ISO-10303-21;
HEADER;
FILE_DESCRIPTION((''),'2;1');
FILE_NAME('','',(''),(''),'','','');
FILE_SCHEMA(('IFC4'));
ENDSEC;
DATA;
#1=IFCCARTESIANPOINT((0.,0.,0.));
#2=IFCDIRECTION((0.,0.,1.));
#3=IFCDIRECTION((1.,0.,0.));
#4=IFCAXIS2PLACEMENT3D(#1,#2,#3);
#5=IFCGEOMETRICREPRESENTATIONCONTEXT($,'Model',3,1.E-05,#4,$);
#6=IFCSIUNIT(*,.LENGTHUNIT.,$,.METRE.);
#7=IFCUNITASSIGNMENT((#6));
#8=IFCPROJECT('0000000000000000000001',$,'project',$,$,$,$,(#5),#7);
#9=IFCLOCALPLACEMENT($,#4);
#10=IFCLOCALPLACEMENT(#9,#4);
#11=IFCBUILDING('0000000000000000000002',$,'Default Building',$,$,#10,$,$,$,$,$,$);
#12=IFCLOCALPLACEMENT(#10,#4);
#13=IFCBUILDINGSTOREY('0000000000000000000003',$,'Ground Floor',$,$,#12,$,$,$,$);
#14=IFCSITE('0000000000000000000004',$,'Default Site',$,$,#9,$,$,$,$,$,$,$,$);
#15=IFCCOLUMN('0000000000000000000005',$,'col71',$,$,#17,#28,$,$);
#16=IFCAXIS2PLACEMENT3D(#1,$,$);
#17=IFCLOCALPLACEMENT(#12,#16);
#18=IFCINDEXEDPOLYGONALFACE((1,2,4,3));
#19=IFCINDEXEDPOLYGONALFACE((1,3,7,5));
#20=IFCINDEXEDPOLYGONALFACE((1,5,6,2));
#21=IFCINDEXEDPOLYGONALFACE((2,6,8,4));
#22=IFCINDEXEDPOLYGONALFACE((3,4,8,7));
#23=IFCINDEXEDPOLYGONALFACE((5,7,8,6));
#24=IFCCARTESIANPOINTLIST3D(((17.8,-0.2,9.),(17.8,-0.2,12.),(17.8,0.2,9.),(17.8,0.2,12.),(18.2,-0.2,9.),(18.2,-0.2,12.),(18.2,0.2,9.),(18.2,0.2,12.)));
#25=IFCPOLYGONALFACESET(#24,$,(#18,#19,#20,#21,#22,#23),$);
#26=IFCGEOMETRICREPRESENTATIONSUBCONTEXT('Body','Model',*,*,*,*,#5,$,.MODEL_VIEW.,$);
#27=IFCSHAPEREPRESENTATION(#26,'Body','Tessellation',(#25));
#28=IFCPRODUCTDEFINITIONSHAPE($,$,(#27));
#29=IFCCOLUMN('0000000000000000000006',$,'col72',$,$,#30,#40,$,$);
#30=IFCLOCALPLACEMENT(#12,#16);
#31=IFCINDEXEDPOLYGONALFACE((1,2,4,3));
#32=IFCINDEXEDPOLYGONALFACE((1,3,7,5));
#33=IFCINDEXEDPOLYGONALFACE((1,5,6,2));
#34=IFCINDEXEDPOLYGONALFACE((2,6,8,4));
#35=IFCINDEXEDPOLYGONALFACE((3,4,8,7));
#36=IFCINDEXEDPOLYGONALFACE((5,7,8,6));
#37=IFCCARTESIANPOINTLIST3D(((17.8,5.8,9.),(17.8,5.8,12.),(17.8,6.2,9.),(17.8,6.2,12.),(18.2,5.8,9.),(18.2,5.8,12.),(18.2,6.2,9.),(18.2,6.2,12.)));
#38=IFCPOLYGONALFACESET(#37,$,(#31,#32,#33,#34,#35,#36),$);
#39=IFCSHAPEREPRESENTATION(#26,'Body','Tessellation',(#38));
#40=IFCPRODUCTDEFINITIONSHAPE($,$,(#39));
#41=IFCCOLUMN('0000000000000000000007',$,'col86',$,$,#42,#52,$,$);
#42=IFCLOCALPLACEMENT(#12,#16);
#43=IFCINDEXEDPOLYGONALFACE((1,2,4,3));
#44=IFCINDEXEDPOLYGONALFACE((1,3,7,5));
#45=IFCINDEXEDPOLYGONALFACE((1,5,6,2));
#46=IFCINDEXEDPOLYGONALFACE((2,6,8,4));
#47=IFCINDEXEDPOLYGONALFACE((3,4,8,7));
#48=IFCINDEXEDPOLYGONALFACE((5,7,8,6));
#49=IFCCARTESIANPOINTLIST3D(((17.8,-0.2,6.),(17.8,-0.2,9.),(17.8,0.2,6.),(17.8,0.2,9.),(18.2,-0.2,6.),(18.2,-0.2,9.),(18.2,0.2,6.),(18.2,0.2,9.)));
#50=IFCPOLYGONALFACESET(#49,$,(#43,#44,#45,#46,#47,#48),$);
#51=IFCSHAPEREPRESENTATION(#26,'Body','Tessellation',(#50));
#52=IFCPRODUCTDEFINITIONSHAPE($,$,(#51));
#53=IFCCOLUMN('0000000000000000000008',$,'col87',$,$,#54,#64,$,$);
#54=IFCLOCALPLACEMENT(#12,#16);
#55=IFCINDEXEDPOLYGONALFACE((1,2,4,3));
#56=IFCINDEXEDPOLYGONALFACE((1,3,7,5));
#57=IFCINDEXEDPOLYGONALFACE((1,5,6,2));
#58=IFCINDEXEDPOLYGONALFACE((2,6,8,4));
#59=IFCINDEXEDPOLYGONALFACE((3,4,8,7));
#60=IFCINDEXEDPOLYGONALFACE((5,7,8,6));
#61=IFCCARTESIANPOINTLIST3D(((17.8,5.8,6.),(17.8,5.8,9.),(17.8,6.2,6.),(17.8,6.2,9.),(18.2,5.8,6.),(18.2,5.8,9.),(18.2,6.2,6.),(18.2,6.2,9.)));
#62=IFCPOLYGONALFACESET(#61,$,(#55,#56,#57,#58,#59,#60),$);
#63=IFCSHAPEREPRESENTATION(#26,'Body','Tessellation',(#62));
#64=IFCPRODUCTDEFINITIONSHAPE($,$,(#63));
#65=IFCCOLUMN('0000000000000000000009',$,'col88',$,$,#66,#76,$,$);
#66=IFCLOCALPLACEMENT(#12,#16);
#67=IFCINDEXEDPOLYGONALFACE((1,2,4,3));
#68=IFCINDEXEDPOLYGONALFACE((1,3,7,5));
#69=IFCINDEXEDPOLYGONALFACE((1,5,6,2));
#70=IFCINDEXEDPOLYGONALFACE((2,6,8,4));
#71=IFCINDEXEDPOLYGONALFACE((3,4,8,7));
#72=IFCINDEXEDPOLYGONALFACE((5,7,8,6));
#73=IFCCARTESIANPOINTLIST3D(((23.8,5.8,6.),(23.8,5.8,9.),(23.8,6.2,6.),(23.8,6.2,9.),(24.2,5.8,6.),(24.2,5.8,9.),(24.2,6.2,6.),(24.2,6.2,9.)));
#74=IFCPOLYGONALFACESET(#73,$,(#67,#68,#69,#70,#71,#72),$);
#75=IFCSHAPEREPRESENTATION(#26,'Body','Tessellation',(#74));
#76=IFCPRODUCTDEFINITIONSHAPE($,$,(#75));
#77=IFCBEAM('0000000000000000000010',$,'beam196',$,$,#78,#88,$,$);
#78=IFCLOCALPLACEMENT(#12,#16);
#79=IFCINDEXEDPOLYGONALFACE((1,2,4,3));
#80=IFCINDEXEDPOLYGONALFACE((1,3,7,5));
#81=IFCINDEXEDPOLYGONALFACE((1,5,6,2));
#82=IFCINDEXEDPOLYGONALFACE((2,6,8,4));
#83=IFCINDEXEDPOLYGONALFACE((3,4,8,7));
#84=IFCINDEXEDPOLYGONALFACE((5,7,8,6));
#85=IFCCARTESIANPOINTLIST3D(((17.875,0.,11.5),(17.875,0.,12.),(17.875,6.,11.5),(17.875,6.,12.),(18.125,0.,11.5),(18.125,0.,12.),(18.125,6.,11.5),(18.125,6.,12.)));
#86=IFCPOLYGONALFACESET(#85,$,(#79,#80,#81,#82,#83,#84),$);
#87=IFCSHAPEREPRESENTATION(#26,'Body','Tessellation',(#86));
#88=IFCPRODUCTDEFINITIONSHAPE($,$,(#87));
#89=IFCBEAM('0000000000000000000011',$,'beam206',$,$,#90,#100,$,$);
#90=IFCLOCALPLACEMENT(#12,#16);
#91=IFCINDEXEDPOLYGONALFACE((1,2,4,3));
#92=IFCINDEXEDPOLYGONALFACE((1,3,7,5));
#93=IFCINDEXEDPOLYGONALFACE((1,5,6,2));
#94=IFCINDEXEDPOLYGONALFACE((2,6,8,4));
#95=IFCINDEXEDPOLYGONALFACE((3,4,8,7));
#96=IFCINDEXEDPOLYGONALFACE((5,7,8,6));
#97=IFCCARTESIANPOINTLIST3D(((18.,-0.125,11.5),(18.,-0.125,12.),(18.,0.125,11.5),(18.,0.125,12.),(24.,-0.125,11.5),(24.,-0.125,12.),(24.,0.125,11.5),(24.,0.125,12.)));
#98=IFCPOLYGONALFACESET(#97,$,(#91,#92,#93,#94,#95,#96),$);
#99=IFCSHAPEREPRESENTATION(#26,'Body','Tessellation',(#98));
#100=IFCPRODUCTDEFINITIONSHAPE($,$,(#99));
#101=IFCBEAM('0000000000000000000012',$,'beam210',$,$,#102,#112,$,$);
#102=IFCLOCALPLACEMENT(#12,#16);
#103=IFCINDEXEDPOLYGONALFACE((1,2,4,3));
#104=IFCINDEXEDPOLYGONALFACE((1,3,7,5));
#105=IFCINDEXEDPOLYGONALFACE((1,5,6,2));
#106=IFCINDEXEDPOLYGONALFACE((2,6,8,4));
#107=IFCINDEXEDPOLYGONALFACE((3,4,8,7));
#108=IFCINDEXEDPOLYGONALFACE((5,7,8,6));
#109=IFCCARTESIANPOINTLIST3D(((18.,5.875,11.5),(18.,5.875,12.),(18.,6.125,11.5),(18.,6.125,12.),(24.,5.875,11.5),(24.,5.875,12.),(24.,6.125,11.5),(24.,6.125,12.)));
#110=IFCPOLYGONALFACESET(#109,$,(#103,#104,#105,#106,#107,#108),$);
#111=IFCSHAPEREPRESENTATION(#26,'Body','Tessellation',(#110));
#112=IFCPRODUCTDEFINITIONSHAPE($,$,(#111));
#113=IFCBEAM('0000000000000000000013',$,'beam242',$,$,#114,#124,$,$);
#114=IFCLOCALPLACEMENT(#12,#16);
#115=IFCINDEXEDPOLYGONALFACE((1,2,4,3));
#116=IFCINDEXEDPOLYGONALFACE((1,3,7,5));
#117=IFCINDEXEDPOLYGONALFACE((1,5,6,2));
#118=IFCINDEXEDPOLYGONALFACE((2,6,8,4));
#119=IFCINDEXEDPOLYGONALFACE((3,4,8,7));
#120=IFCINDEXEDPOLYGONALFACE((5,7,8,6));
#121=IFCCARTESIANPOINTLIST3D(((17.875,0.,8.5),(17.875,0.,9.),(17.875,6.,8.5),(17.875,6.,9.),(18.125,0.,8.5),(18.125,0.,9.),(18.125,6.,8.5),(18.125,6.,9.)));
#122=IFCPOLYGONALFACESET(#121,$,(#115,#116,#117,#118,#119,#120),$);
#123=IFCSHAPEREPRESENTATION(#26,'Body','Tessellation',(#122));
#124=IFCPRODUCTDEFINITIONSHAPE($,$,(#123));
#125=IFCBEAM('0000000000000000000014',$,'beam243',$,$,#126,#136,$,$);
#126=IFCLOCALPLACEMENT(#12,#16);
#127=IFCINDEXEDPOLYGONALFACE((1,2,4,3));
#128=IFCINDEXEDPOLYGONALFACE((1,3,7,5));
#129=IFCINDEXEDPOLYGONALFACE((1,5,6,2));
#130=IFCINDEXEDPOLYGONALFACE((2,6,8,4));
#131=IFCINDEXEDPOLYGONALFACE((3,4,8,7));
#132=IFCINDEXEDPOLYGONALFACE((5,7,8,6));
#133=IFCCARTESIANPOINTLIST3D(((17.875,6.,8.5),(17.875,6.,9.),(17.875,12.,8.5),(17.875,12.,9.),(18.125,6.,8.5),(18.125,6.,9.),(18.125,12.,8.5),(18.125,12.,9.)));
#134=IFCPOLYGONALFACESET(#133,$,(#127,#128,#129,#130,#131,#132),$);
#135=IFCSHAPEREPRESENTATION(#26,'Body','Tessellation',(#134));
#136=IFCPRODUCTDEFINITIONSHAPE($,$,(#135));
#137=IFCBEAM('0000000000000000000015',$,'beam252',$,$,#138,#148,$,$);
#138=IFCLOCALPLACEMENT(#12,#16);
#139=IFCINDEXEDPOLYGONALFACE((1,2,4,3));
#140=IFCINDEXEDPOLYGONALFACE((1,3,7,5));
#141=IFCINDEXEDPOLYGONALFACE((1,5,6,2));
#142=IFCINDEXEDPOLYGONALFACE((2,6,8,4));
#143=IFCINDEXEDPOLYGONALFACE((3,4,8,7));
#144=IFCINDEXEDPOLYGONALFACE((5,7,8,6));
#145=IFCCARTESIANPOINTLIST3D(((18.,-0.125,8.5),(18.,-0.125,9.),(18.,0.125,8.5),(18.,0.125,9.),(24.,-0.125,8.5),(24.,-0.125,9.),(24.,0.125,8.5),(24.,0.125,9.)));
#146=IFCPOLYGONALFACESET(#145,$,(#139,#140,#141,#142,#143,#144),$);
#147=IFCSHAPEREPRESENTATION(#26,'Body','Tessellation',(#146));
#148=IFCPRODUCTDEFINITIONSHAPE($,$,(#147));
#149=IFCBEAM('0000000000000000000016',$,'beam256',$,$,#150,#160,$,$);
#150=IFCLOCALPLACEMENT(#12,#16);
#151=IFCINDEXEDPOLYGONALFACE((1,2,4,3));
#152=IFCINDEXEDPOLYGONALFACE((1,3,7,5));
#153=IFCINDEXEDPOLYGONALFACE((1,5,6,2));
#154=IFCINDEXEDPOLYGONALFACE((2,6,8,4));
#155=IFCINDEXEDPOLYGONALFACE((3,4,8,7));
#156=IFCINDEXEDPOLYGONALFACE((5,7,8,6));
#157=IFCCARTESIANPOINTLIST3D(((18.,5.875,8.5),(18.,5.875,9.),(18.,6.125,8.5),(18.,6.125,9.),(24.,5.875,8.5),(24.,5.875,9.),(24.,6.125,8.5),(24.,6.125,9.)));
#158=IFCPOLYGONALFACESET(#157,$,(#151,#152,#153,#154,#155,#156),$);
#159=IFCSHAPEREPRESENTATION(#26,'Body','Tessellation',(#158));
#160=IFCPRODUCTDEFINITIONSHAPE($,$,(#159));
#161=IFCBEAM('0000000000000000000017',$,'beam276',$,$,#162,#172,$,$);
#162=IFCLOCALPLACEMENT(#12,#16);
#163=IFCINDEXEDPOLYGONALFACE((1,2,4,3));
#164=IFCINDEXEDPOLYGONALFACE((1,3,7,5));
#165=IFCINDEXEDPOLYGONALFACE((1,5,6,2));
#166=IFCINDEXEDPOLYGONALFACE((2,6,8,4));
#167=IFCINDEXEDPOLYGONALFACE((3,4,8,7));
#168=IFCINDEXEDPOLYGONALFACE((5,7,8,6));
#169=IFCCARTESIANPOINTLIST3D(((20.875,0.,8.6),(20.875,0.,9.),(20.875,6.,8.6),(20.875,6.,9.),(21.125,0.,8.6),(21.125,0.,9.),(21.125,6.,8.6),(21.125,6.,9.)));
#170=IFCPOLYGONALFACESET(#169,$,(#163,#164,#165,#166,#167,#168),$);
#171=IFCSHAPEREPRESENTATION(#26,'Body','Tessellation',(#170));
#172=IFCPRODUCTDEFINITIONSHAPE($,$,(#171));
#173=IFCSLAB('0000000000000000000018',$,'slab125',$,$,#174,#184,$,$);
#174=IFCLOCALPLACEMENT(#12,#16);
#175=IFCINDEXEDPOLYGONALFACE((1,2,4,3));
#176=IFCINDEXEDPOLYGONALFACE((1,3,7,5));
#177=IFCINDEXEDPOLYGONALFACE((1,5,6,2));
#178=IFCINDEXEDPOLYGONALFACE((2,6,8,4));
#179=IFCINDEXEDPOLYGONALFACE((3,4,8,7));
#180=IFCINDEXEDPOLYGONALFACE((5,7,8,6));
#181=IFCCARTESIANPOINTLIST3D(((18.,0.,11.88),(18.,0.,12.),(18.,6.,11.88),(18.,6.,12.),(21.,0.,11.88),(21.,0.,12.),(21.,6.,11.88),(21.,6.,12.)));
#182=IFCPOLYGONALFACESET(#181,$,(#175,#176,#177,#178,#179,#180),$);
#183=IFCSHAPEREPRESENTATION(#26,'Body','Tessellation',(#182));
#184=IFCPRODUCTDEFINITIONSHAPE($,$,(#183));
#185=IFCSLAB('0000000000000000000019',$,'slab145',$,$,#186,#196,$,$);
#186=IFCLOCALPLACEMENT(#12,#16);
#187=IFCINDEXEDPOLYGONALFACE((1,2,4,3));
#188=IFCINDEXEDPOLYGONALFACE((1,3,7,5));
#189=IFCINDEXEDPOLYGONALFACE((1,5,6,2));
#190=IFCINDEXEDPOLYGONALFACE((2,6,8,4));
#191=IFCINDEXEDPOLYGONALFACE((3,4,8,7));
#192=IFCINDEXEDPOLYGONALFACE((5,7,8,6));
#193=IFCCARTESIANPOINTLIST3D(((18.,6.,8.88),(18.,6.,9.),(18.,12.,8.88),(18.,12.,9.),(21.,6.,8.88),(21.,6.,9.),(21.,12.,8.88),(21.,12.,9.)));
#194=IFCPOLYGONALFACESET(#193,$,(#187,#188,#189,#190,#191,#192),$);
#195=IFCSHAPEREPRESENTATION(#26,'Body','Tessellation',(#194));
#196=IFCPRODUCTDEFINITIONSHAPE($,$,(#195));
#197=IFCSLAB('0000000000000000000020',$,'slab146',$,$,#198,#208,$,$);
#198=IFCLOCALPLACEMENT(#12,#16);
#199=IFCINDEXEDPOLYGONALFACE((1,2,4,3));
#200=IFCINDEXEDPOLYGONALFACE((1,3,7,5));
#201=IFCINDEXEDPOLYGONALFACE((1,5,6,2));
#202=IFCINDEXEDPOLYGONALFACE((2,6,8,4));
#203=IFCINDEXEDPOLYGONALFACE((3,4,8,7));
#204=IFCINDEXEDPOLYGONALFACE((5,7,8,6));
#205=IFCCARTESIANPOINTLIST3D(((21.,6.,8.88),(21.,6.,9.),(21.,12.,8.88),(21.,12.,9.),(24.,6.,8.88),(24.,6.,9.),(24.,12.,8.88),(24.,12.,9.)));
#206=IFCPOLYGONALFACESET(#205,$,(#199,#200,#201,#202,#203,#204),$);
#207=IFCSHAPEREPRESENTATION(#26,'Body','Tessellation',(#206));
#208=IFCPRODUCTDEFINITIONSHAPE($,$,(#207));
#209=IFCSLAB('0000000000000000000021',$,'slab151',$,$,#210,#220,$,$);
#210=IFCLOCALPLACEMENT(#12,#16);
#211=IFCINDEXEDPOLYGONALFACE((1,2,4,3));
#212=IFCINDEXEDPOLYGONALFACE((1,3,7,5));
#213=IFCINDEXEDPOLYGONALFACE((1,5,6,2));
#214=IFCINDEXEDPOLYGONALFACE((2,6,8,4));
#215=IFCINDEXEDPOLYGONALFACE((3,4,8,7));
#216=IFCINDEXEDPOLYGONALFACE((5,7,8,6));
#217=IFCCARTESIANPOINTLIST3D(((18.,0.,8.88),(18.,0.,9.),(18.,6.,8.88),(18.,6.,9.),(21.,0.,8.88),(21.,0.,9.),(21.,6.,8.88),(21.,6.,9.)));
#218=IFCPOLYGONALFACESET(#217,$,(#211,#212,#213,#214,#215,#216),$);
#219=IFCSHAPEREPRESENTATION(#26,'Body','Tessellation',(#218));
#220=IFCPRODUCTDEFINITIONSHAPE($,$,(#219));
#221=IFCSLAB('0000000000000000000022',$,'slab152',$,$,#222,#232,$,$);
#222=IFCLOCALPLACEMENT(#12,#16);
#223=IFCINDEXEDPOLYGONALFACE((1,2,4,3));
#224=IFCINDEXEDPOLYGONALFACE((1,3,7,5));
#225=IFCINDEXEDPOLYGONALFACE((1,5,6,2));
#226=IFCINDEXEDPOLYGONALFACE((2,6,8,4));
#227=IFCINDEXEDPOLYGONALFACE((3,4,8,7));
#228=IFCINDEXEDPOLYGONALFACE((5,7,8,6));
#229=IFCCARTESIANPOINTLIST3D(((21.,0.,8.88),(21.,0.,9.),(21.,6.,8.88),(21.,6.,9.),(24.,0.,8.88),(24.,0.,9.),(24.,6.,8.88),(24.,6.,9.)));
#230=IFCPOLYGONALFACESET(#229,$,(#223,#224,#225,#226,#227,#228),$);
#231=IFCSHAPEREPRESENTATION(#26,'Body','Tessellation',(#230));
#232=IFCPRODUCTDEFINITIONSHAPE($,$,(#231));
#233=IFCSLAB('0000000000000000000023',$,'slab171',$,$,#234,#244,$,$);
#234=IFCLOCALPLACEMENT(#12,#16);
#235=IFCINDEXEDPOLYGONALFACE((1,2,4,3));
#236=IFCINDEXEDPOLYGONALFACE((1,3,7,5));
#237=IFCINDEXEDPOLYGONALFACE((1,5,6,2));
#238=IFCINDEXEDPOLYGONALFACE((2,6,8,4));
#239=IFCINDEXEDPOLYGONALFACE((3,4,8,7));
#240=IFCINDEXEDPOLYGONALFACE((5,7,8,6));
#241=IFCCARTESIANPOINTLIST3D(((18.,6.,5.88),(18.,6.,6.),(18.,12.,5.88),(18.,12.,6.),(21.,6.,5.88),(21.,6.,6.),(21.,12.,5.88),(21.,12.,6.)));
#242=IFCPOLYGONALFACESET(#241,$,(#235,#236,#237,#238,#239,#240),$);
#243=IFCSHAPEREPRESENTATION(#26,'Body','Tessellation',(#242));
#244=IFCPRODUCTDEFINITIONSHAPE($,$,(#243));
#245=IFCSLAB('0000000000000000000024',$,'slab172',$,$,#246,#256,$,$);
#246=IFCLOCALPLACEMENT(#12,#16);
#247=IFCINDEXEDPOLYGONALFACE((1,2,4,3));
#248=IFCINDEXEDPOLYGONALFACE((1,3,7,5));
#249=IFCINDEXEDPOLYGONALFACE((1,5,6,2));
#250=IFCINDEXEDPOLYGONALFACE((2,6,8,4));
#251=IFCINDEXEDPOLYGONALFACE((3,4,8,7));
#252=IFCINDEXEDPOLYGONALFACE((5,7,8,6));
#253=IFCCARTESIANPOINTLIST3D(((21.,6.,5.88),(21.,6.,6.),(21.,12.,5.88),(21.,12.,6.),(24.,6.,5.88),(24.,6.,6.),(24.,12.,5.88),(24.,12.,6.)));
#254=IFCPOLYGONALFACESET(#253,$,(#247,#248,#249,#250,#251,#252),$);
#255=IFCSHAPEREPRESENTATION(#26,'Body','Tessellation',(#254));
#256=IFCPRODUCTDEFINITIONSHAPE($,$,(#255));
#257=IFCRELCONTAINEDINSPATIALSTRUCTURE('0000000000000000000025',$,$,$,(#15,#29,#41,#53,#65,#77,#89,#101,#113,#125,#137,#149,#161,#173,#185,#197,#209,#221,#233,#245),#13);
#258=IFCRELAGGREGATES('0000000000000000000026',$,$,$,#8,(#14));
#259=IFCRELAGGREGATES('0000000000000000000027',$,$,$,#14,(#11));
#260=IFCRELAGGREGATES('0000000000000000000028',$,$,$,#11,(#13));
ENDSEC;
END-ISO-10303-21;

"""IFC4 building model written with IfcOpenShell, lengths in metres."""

from ifc_helpers import new_model, si_unit, frame, origin_with_axes, place, context, subcontext, project, spatial, indexed_curve, outline, extrude, element, save


model = new_model("IFC4")

# Units and contexts
model_context = context("Model", 3, precision=1e-05, world=origin_with_axes())
body_context = subcontext(model_context, "Body", "Model", "MODEL_VIEW")
ifc_project = project(units=[si_unit("LENGTHUNIT", "METRE")], contexts=[model_context])

# Site, building, storey
site_placement = place(None, origin_with_axes())
site = spatial("IfcSite", under=ifc_project, at=site_placement, Name="Default Site")
building_placement = place(site_placement, origin_with_axes())
building = spatial("IfcBuilding", under=site, at=building_placement, Name="Default Building")
storey_placement = place(building_placement, origin_with_axes())
storey = spatial("IfcBuildingStorey", under=building, at=storey_placement, Name="Ground Floor")

# Columns
for number, where, z_axis, x_axis, name in (
    (1, (17.8, -0.2, 9.0), (0.0, 0.0, 1.0), (1.0, 0.0, 0.0), "col71"),
    (2, (17.8, 5.8, 9.0), (0.0, 0.0, 1.0), (1.0, 0.0, 0.0), "col72"),
    (3, (17.8, -0.2, 6.0), (0.0, 0.0, 1.0), (1.0, 0.0, 0.0), "col86"),
    (4, (17.8, 5.8, 6.0), (0.0, 0.0, 1.0), (1.0, 0.0, 0.0), "col87"),
    (5, (23.8, 5.8, 6.0), (0.0, 0.0, 1.0), (1.0, 0.0, 0.0), "col88"),
):
    element("IfcColumn", number, at=place(storey_placement, frame(where, z_axis=z_axis, x_axis=x_axis)), inside=storey, Name=name, context=body_context, shape_type="SweptSolid", body=[
        extrude(outline(indexed_curve([(0.0, 0.0), (0.0, 0.4), (0.4, 0.4), (0.4, 0.0), (0.0, 0.0)], self_intersect=False)), origin_with_axes(), (0.0, 0.0, 1.0), 3.0),
    ])

# Beams
for number, where, z_axis, x_axis, name in (
    (6, (18.125, 0.0, 11.5), (0.0, 0.0, 1.0), (0.0, 1.0, 0.0), "beam196"),
    (7, (18.0, -0.125, 11.5), (0.0, 0.0, 1.0), (1.0, 0.0, 0.0), "beam206"),
    (8, (18.0, 5.875, 11.5), (0.0, 0.0, 1.0), (1.0, 0.0, 0.0), "beam210"),
    (9, (18.125, 0.0, 8.5), (0.0, 0.0, 1.0), (0.0, 1.0, 0.0), "beam242"),
    (10, (18.125, 6.0, 8.5), (0.0, 0.0, 1.0), (0.0, 1.0, 0.0), "beam243"),
    (11, (18.0, -0.125, 8.5), (0.0, 0.0, 1.0), (1.0, 0.0, 0.0), "beam252"),
    (12, (18.0, 5.875, 8.5), (0.0, 0.0, 1.0), (1.0, 0.0, 0.0), "beam256"),
):
    element("IfcBeam", number, at=place(storey_placement, frame(where, z_axis=z_axis, x_axis=x_axis)), inside=storey, Name=name, context=body_context, shape_type="SweptSolid", body=[
        extrude(outline(indexed_curve([(0.0, 0.0), (0.0, 0.25), (6.0, 0.25), (6.0, 0.0), (0.0, 0.0)], self_intersect=False)), origin_with_axes(), (0.0, 0.0, 1.0), 0.5),
    ])
beam_placement = place(storey_placement, frame((20.875, 6.0, 8.6), z_axis=(0.0, 0.0, 1.0), x_axis=(0.0, -1.0, 0.0)))
element("IfcBeam", 13, at=beam_placement, inside=storey, Name="beam276", context=body_context, shape_type="SweptSolid", body=[
    extrude(outline(indexed_curve([(0.0, 0.0), (0.0, 0.25), (6.0, 0.25), (6.0, 0.0), (0.0, 0.0)], self_intersect=False)), origin_with_axes(), (0.0, 0.0, 1.0), 0.4),
])

# Slabs
for number, where, z_axis, x_axis, name in (
    (14, (18.0, 0.0, 11.88), (0.0, 0.0, 1.0), (1.0, 0.0, 0.0), "slab125"),
    (15, (18.0, 6.0, 8.88), (0.0, 0.0, 1.0), (1.0, 0.0, 0.0), "slab145"),
    (16, (21.0, 6.0, 8.88), (0.0, 0.0, 1.0), (1.0, 0.0, 0.0), "slab146"),
    (17, (18.0, 0.0, 8.88), (0.0, 0.0, 1.0), (1.0, 0.0, 0.0), "slab151"),
    (18, (21.0, 0.0, 8.88), (0.0, 0.0, 1.0), (1.0, 0.0, 0.0), "slab152"),
    (19, (18.0, 6.0, 5.88), (0.0, 0.0, 1.0), (1.0, 0.0, 0.0), "slab171"),
    (20, (21.0, 6.0, 5.88), (0.0, 0.0, 1.0), (1.0, 0.0, 0.0), "slab172"),
):
    element("IfcSlab", number, at=place(storey_placement, frame(where, z_axis=z_axis, x_axis=x_axis)), inside=storey, Name=name, context=body_context, shape_type="SweptSolid", body=[
        extrude(outline(indexed_curve([(0.0, 0.0), (0.0, 6.0), (3.0, 6.0), (3.0, 0.0), (0.0, 0.0)], self_intersect=False)), origin_with_axes(), (0.0, 0.0, 1.0), 0.12),
    ])

save(model, "model.ifc")
